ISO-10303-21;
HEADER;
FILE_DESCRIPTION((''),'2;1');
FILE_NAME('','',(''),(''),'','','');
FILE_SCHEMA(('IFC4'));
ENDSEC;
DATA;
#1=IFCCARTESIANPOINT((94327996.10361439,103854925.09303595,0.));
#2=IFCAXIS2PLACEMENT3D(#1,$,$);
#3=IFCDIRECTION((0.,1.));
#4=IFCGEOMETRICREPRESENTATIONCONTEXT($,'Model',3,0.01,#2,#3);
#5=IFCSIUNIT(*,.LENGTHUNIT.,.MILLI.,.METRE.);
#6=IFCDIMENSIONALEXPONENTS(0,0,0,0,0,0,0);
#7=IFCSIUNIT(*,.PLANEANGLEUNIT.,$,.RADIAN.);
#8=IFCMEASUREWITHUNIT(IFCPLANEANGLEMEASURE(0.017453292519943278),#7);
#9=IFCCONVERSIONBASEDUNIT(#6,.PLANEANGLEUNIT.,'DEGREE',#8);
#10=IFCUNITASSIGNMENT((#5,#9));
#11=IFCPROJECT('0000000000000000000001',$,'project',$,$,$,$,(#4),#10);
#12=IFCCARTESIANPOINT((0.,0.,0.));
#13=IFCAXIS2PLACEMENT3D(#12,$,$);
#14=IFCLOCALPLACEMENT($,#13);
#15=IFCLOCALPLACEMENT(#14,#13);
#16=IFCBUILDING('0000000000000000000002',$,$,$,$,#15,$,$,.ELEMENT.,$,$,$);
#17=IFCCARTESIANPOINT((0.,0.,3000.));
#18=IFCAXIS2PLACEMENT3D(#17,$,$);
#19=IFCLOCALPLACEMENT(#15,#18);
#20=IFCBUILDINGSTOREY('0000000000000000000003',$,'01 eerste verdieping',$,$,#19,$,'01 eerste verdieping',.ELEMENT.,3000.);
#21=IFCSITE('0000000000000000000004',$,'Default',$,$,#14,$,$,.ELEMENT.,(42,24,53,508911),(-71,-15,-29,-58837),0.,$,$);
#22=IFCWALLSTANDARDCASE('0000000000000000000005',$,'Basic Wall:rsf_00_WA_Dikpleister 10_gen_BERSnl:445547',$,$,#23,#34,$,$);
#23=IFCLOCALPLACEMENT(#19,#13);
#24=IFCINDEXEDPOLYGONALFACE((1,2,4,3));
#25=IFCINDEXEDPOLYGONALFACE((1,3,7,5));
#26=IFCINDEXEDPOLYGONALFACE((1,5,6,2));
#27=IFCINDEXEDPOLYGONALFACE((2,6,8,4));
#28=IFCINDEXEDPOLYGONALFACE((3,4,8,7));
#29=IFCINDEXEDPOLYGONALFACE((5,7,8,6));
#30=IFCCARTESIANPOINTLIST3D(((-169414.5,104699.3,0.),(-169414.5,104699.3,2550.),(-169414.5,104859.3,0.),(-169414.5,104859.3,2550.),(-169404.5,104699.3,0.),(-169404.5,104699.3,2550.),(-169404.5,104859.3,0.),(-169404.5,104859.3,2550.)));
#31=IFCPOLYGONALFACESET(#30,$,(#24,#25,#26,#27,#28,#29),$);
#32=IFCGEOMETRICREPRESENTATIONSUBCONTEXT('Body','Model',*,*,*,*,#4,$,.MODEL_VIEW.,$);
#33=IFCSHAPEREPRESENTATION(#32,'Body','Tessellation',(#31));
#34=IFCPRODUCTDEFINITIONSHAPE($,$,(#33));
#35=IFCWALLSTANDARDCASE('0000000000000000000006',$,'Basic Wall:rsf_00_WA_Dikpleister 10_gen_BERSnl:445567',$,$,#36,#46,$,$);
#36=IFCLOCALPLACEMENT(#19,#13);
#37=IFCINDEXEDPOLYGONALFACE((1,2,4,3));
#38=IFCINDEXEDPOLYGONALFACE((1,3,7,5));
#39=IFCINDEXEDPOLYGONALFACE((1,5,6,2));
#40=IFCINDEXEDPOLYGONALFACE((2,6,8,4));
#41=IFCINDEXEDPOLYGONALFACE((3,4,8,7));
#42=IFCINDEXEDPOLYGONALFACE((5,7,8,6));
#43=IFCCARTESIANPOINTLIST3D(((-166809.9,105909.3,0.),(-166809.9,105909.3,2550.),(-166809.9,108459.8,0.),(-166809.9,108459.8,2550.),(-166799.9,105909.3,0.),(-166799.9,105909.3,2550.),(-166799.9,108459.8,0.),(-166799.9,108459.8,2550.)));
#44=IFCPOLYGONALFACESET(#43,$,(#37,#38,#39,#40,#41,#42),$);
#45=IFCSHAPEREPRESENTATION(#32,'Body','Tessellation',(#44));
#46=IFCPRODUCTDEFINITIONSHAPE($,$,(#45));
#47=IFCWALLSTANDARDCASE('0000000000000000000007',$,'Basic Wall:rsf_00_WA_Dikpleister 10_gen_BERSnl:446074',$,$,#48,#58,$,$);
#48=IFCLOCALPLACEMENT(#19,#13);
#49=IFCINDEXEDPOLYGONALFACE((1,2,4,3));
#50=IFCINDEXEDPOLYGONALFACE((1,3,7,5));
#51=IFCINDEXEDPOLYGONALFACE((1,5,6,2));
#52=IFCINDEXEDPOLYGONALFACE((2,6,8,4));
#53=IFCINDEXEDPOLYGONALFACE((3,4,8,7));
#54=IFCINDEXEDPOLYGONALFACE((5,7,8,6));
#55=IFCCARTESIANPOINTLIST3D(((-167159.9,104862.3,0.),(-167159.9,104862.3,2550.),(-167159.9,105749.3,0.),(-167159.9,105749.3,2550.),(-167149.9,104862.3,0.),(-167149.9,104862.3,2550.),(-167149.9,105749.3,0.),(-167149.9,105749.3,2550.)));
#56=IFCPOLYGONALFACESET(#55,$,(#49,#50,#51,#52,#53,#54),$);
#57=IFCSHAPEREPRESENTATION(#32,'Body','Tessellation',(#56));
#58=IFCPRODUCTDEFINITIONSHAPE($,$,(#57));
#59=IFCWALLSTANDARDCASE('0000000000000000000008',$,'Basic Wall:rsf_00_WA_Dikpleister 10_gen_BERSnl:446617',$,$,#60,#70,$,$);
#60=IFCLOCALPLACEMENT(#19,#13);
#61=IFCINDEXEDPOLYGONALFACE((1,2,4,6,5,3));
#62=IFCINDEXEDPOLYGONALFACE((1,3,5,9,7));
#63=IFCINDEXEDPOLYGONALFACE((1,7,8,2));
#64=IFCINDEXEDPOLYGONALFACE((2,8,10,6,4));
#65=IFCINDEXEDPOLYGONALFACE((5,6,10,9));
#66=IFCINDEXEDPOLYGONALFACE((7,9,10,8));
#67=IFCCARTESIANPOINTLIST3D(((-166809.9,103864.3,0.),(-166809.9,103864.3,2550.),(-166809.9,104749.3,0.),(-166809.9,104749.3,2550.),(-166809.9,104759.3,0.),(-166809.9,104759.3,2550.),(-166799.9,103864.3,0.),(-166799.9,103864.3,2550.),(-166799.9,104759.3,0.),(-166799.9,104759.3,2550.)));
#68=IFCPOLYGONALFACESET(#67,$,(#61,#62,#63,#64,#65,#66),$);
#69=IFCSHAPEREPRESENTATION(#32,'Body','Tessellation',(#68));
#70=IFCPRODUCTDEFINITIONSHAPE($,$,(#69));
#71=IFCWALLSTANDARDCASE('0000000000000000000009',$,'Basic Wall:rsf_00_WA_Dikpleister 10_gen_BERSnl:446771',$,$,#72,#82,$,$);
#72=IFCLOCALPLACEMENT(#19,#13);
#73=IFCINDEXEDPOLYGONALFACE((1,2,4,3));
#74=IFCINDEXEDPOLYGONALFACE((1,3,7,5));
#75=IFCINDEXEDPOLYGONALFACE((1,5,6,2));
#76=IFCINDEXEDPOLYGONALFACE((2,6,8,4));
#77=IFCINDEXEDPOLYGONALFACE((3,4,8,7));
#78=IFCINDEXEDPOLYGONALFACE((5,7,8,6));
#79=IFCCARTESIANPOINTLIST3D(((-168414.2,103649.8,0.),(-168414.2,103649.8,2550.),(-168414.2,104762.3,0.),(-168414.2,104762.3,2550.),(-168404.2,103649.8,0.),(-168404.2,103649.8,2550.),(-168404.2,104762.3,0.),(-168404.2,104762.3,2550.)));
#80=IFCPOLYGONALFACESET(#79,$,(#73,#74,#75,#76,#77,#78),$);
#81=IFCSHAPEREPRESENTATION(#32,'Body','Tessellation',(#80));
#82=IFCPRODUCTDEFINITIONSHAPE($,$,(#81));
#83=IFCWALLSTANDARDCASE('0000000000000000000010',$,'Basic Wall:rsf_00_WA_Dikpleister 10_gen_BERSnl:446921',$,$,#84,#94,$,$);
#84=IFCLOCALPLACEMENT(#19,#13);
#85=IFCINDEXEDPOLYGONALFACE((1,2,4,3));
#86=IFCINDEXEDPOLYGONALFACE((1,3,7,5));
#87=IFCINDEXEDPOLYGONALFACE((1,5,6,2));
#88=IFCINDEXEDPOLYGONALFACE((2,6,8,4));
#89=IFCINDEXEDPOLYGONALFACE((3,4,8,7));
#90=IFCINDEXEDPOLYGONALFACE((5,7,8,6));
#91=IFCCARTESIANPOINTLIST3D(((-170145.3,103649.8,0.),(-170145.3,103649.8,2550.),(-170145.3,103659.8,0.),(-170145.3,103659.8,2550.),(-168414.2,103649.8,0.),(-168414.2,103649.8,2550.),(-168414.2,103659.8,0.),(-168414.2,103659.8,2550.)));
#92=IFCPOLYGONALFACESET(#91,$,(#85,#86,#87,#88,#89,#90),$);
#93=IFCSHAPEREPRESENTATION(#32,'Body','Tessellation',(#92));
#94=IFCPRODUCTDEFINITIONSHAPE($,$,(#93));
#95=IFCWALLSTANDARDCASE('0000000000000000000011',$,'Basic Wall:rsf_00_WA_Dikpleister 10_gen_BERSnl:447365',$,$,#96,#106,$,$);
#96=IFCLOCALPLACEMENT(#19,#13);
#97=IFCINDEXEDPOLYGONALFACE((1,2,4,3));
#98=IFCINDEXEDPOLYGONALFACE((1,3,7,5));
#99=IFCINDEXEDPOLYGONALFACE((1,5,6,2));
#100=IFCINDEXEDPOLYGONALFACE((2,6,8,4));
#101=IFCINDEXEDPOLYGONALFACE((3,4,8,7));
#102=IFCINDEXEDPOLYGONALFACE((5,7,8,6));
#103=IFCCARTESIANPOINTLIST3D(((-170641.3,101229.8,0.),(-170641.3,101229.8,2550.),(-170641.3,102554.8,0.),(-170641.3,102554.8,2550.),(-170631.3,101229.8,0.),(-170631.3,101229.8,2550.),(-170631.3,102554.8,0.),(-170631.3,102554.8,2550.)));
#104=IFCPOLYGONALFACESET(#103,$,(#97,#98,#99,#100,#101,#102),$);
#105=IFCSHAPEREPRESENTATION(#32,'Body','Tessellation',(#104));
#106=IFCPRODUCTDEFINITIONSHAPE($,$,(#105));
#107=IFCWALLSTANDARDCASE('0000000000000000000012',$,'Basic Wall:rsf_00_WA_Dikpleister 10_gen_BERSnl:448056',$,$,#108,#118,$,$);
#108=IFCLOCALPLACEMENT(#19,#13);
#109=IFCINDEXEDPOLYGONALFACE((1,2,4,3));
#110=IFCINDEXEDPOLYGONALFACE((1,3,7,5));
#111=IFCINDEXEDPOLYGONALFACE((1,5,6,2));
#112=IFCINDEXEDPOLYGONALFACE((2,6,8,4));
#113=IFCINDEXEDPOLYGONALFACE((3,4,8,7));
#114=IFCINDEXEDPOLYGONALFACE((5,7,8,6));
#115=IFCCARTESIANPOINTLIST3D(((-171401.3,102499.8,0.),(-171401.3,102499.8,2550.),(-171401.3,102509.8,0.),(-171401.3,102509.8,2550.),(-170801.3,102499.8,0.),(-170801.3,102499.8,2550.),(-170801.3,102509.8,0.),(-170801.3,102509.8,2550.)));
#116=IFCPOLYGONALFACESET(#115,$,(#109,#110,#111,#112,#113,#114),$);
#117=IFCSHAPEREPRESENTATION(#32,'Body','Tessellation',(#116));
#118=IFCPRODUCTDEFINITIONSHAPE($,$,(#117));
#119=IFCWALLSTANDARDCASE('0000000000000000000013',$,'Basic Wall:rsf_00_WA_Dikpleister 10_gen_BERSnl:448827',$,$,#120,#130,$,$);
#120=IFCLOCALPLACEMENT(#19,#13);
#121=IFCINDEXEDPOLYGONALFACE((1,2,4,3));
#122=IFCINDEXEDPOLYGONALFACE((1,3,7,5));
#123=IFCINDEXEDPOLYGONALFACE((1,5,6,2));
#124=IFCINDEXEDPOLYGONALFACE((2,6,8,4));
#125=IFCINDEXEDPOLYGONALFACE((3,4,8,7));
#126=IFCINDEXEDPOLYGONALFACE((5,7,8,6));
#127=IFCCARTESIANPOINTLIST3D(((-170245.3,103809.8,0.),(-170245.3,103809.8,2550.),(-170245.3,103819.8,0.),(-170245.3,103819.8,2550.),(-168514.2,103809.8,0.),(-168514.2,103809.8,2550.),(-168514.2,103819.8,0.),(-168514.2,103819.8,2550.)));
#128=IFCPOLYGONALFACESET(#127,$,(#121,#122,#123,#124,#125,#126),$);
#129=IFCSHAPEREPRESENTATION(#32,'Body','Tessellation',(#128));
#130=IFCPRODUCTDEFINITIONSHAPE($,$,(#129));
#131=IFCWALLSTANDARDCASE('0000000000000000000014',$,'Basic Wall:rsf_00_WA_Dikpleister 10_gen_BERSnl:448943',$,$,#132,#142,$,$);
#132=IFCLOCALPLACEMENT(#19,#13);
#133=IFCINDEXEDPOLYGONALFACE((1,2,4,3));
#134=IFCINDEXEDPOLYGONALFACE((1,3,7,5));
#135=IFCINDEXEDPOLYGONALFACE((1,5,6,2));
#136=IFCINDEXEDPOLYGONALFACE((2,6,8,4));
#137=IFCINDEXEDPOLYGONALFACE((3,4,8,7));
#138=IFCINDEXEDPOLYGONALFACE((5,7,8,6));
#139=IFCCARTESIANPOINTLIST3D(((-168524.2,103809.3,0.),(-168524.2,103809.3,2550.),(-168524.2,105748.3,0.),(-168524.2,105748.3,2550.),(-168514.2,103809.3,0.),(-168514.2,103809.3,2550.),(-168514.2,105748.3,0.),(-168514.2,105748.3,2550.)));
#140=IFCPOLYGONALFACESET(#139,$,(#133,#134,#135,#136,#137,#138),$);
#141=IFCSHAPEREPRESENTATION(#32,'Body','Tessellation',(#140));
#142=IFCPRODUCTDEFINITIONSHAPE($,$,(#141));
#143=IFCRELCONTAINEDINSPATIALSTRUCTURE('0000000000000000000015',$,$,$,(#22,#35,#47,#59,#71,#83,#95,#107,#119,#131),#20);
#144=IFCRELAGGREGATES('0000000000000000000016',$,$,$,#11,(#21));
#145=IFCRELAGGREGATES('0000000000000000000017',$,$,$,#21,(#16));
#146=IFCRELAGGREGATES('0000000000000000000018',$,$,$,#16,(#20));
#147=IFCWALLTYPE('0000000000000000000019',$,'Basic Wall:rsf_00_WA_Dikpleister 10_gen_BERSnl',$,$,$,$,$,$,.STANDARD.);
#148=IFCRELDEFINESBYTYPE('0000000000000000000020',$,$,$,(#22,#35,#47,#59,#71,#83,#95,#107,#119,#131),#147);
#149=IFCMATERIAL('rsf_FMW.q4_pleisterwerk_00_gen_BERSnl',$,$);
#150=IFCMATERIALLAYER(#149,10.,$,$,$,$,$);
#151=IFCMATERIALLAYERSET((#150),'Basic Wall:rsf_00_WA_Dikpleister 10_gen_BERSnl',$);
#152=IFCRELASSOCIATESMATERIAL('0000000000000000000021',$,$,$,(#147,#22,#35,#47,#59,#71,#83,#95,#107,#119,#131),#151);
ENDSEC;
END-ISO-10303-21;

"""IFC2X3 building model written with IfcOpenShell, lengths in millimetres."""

from ifc_helpers import new_model, entity, si_unit, converted_unit, direction, frame, frame_2d, origin, place, context, subcontext, project, spatial, polyline, rectangle, outline, extrude, material, layer, layer_set, layer_usage, type_object, element, save


model = new_model("IFC2X3")

# Units and contexts
model_context = context("Model", 3, precision=0.01, world=frame((94327996.10361439, 103854925.09303595, 0.0)), true_north=direction((0.0, 1.0)))
body_context = subcontext(model_context, "Body", "Model", "MODEL_VIEW")
ifc_project = project(units=[si_unit("LENGTHUNIT", "METRE", prefix="MILLI"), converted_unit("PLANEANGLEUNIT", "DEGREE", entity("IfcPlaneAngleMeasure", 0.017453292519943278), si_unit("PLANEANGLEUNIT", "RADIAN"), dimensions=[0, 0, 0, 0, 0, 0, 0])], contexts=[model_context])

# Site, building, storey
site_placement = place(None, origin())
site = spatial("IfcSite", under=ifc_project, at=site_placement, Name="Default", CompositionType="ELEMENT", RefLatitude=(42, 24, 53, 508911), RefLongitude=(-71, -15, -29, -58837), RefElevation=0.0)
building_placement = place(site_placement, origin())
building = spatial("IfcBuilding", under=site, at=building_placement, CompositionType="ELEMENT")
storey_placement = place(building_placement, frame((0.0, 0.0, 3000.0)))
storey = spatial("IfcBuildingStorey", under=building, at=storey_placement, Name="01 eerste verdieping", LongName="01 eerste verdieping", CompositionType="ELEMENT", Elevation=3000.0)

# Shared definitions
ifc_material_1 = material(Name="rsf_FMW.q4_pleisterwerk_00_gen_BERSnl")

# Walls
ifc_layer_1 = layer(ifc_material_1, 10.0)
ifc_layer_set_1 = layer_set([ifc_layer_1], Name="Basic Wall:rsf_00_WA_Dikpleister 10_gen_BERSnl")
wall_type_1 = type_object("IfcWallType", Name="Basic Wall:rsf_00_WA_Dikpleister 10_gen_BERSnl", PredefinedType="STANDARD", material=ifc_layer_set_1)
ifc_layer_usage_1 = layer_usage(ifc_layer_set_1, "AXIS2", "NEGATIVE", 5.0)
wall_1_placement = place(storey_placement, frame((-169409.5, 104699.3, 0.0), z_axis=(0.0, 0.0, 1.0), x_axis=(0.0, 1.0, 0.0)))
element("IfcWallStandardCase", 1, at=wall_1_placement, inside=storey, type_object=wall_type_1, material=ifc_layer_usage_1, Name="Basic Wall:rsf_00_WA_Dikpleister 10_gen_BERSnl:445547", context=body_context, shape_type="SweptSolid", body=[
    extrude(rectangle(XDim=160.0, YDim=10.0, at=frame_2d((80.0, 0.0), x_axis=(-1.0, 0.0))), origin(), (0.0, 0.0, 1.0), 2550.0),
])
ifc_layer_usage_2 = layer_usage(ifc_layer_set_1, "AXIS2", "POSITIVE", -5.0)
wall_2_placement = place(storey_placement, frame((-166804.9, 105909.3, 0.0), z_axis=(0.0, 0.0, 1.0), x_axis=(0.0, 1.0, 0.0)))
element("IfcWallStandardCase", 2, at=wall_2_placement, inside=storey, type_object=wall_type_1, material=ifc_layer_usage_2, Name="Basic Wall:rsf_00_WA_Dikpleister 10_gen_BERSnl:445567", context=body_context, shape_type="SweptSolid", body=[
    extrude(rectangle(XDim=2550.5, YDim=10.0, at=frame_2d((1275.2, 0.0), x_axis=(-1.0, 0.0))), origin(), (0.0, 0.0, 1.0), 2550.0),
])

# Walls
ifc_layer_usage_3 = layer_usage(ifc_layer_set_1, "AXIS2", "POSITIVE", -5.0)
wall_3_placement = place(storey_placement, frame((-167154.9, 105749.3, 0.0), z_axis=(0.0, 0.0, 1.0), x_axis=(0.0, -1.0, 0.0)))
element("IfcWallStandardCase", 3, at=wall_3_placement, inside=storey, type_object=wall_type_1, material=ifc_layer_usage_3, Name="Basic Wall:rsf_00_WA_Dikpleister 10_gen_BERSnl:446074", context=body_context, shape_type="SweptSolid", body=[
    extrude(rectangle(XDim=887.0, YDim=10.0, at=frame_2d((443.5, 0.0), x_axis=(-1.0, 0.0))), origin(), (0.0, 0.0, 1.0), 2550.0),
])
ifc_layer_usage_4 = layer_usage(ifc_layer_set_1, "AXIS2", "NEGATIVE", 5.0)
wall_4_placement = place(storey_placement, frame((-166804.9, 103864.3, 0.0), z_axis=(0.0, 0.0, 1.0), x_axis=(0.0, 1.0, 0.0)))
element("IfcWallStandardCase", 4, at=wall_4_placement, inside=storey, type_object=wall_type_1, material=ifc_layer_usage_4, Name="Basic Wall:rsf_00_WA_Dikpleister 10_gen_BERSnl:446617", context=body_context, shape_type="SweptSolid", body=[
    extrude(outline(polyline([(895.0, -5.0), (895.0, 5.0), (885.0, 5.0), (0.0, 5.0), (0.0, -5.0), (895.0, -5.0)])), origin(), (0.0, 0.0, 1.0), 2550.0),
])
ifc_layer_usage_5 = layer_usage(ifc_layer_set_1, "AXIS2", "NEGATIVE", 5.0)
wall_5_placement = place(storey_placement, frame((-168409.2, 104762.3, 0.0), z_axis=(0.0, 0.0, 1.0), x_axis=(0.0, -1.0, 0.0)))
element("IfcWallStandardCase", 5, at=wall_5_placement, inside=storey, type_object=wall_type_1, material=ifc_layer_usage_5, Name="Basic Wall:rsf_00_WA_Dikpleister 10_gen_BERSnl:446771", context=body_context, shape_type="SweptSolid", body=[
    extrude(rectangle(XDim=1112.5, YDim=10.0, at=frame_2d((556.3, 0.0), x_axis=(-1.0, 0.0))), origin(), (0.0, 0.0, 1.0), 2550.0),
])
ifc_layer_usage_6 = layer_usage(ifc_layer_set_1, "AXIS2", "NEGATIVE", 5.0)
wall_6_placement = place(storey_placement, frame((-168414.2, 103654.8, 0.0), z_axis=(0.0, 0.0, 1.0), x_axis=(-1.0, 0.0, 0.0)))
element("IfcWallStandardCase", 6, at=wall_6_placement, inside=storey, type_object=wall_type_1, material=ifc_layer_usage_6, Name="Basic Wall:rsf_00_WA_Dikpleister 10_gen_BERSnl:446921", context=body_context, shape_type="SweptSolid", body=[
    extrude(rectangle(XDim=1731.2, YDim=10.0, at=frame_2d((865.6, 0.0), x_axis=(-1.0, 0.0))), origin(), (0.0, 0.0, 1.0), 2550.0),
])
ifc_layer_usage_7 = layer_usage(ifc_layer_set_1, "AXIS2", "NEGATIVE", 5.0)
wall_7_placement = place(storey_placement, frame((-170636.3, 102554.8, 0.0), z_axis=(0.0, 0.0, 1.0), x_axis=(0.0, -1.0, 0.0)))
element("IfcWallStandardCase", 7, at=wall_7_placement, inside=storey, type_object=wall_type_1, material=ifc_layer_usage_7, Name="Basic Wall:rsf_00_WA_Dikpleister 10_gen_BERSnl:447365", context=body_context, shape_type="SweptSolid", body=[
    extrude(rectangle(XDim=1325.0, YDim=10.0, at=frame_2d((662.5, 0.0), x_axis=(-1.0, 0.0))), origin(), (0.0, 0.0, 1.0), 2550.0),
])
ifc_layer_usage_8 = layer_usage(ifc_layer_set_1, "AXIS2", "NEGATIVE", 5.0)
wall_8_placement = place(storey_placement, frame((-170801.3, 102504.8, 0.0), z_axis=(0.0, 0.0, 1.0), x_axis=(-1.0, 0.0, 0.0)))
element("IfcWallStandardCase", 8, at=wall_8_placement, inside=storey, type_object=wall_type_1, material=ifc_layer_usage_8, Name="Basic Wall:rsf_00_WA_Dikpleister 10_gen_BERSnl:448056", context=body_context, shape_type="SweptSolid", body=[
    extrude(rectangle(XDim=600.0, YDim=10.0, at=frame_2d((300.0, 0.0), x_axis=(-1.0, 0.0))), origin(), (0.0, 0.0, 1.0), 2550.0),
])

# Walls
ifc_layer_usage_9 = layer_usage(ifc_layer_set_1, "AXIS2", "NEGATIVE", 5.0)
wall_9_placement = place(storey_placement, frame((-170245.3, 103814.8, 0.0)))
element("IfcWallStandardCase", 9, at=wall_9_placement, inside=storey, type_object=wall_type_1, material=ifc_layer_usage_9, Name="Basic Wall:rsf_00_WA_Dikpleister 10_gen_BERSnl:448827", context=body_context, shape_type="SweptSolid", body=[
    extrude(rectangle(XDim=1731.2, YDim=10.0, at=frame_2d((865.6, 0.0), x_axis=(-1.0, 0.0))), origin(), (0.0, 0.0, 1.0), 2550.0),
])
ifc_layer_usage_10 = layer_usage(ifc_layer_set_1, "AXIS2", "NEGATIVE", 5.0)
wall_10_placement = place(storey_placement, frame((-168519.2, 103809.3, 0.0), z_axis=(0.0, 0.0, 1.0), x_axis=(0.0, 1.0, 0.0)))
element("IfcWallStandardCase", 10, at=wall_10_placement, inside=storey, type_object=wall_type_1, material=ifc_layer_usage_10, Name="Basic Wall:rsf_00_WA_Dikpleister 10_gen_BERSnl:448943", context=body_context, shape_type="SweptSolid", body=[
    extrude(rectangle(XDim=1939.0, YDim=10.0, at=frame_2d((969.5, 0.0), x_axis=(-1.0, 0.0))), origin(), (0.0, 0.0, 1.0), 2550.0),
])

save(model, "model.ifc")
